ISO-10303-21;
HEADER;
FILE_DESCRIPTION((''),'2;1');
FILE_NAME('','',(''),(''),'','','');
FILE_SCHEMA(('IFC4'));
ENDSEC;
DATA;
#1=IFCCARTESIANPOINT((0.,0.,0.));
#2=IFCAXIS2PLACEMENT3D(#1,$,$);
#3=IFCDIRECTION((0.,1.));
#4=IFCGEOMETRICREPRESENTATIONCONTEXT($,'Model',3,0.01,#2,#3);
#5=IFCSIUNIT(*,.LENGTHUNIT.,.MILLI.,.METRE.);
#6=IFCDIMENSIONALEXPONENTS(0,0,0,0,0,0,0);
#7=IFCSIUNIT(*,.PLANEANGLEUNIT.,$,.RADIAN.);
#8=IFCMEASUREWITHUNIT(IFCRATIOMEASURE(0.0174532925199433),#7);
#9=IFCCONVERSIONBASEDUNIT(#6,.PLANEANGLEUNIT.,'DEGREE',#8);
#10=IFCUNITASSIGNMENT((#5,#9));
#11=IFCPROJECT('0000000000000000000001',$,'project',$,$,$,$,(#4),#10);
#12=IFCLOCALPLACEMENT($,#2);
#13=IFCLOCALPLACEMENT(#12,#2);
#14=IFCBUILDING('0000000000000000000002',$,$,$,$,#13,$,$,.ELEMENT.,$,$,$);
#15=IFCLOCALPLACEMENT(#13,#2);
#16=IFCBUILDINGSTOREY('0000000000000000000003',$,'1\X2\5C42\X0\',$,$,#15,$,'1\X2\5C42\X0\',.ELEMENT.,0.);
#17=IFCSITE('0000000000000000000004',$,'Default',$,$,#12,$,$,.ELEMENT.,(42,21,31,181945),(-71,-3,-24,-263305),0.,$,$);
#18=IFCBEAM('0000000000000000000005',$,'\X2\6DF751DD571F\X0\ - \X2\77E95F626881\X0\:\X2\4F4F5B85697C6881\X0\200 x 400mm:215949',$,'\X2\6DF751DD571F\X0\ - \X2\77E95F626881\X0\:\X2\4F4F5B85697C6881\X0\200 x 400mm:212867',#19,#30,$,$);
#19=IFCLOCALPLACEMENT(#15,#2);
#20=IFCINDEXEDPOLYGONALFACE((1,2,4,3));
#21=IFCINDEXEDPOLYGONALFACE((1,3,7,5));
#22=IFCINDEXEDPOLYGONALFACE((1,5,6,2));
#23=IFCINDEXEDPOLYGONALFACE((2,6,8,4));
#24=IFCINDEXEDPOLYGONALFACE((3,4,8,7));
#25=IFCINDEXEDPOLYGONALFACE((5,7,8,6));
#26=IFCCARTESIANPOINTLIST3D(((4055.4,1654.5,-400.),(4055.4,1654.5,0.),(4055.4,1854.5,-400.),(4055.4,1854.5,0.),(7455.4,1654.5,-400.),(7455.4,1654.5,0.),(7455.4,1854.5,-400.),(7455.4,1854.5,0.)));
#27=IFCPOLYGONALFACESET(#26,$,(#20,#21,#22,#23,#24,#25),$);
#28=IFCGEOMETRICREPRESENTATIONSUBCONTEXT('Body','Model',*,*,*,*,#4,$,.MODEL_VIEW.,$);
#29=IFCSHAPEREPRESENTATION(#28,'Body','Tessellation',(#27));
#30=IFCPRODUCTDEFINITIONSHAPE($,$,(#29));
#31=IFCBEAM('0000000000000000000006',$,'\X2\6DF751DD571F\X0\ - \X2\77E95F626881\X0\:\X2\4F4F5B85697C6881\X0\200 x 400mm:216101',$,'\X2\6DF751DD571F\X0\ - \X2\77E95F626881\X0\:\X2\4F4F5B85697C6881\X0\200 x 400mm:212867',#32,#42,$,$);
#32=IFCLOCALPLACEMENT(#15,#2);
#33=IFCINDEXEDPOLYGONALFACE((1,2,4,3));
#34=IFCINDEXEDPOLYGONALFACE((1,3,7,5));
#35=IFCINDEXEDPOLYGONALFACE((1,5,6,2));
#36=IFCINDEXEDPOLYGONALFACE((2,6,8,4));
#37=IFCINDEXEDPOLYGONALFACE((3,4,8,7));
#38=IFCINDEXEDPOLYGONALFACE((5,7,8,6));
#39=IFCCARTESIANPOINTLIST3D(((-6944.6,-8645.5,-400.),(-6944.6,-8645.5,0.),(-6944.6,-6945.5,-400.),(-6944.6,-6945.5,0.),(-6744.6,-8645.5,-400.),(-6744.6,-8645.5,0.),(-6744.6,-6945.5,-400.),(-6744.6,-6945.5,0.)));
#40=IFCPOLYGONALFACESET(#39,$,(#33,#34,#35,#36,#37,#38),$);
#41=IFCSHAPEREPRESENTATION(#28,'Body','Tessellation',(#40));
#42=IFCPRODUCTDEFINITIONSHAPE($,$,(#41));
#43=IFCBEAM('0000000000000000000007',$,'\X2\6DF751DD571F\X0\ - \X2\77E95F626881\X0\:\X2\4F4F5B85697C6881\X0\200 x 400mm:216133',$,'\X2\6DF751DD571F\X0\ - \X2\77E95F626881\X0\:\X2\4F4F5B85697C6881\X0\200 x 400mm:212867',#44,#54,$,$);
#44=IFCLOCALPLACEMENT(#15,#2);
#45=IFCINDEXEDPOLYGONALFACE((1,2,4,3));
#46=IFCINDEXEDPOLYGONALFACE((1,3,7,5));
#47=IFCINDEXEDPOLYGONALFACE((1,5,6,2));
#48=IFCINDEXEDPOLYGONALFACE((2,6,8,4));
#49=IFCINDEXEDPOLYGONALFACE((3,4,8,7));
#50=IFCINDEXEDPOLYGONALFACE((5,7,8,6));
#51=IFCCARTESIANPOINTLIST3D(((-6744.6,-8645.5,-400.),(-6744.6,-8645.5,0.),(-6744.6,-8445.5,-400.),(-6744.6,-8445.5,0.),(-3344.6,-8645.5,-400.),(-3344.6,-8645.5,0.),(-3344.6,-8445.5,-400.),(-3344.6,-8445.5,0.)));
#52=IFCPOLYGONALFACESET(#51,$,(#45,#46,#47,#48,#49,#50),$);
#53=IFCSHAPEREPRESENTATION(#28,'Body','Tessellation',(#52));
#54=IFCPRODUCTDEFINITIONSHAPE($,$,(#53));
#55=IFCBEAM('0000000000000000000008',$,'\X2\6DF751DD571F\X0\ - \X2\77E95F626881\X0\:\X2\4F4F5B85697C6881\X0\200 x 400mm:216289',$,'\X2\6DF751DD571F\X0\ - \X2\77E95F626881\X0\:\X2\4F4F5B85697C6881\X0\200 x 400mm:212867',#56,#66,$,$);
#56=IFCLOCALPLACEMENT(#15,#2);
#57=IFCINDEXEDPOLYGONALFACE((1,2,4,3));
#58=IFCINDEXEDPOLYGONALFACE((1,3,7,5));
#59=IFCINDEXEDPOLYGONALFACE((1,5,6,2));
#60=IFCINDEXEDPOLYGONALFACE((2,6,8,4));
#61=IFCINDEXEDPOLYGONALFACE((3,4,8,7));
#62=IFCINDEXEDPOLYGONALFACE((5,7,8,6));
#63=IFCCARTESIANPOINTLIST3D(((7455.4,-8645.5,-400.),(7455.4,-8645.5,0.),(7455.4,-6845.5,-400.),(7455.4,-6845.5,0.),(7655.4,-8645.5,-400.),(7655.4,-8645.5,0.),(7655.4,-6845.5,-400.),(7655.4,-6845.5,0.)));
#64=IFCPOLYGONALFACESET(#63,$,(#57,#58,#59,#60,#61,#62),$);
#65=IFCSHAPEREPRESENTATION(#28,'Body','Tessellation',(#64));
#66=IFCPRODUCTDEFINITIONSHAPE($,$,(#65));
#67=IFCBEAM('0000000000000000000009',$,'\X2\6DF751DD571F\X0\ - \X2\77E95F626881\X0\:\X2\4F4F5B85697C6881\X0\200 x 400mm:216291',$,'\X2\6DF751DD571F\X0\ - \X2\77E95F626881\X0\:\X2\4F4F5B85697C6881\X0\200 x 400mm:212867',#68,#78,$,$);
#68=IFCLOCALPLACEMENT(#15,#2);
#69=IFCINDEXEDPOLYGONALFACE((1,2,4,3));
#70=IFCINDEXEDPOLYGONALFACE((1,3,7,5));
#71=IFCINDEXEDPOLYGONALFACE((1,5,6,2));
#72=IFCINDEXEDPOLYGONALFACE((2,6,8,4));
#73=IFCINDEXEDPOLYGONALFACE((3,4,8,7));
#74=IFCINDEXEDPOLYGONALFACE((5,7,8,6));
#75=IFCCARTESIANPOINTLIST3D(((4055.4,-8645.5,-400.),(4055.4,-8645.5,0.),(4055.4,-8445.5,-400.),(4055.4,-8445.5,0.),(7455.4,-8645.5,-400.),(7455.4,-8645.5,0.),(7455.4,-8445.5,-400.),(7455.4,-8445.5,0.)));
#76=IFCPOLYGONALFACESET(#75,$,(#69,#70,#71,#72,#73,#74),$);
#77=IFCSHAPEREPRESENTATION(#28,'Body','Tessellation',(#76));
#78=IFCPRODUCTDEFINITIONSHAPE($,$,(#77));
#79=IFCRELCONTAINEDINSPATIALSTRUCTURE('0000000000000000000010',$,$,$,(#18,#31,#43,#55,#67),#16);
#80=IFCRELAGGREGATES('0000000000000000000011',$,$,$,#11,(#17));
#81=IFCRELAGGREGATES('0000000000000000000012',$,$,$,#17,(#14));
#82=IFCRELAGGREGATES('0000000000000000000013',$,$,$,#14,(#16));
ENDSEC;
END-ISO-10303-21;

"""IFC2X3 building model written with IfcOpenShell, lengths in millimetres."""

from ifc_helpers import new_model, entity, si_unit, converted_unit, direction, frame, frame_2d, origin, place, context, subcontext, project, spatial, rectangle, extrude, element, save


model = new_model("IFC2X3")

# Units and contexts
model_context = context("Model", 3, precision=0.01, world=origin(), true_north=direction((0.0, 1.0)))
body_context = subcontext(model_context, "Body", "Model", "MODEL_VIEW")
ifc_project = project(units=[si_unit("LENGTHUNIT", "METRE", prefix="MILLI"), converted_unit("PLANEANGLEUNIT", "DEGREE", entity("IfcRatioMeasure", 0.0174532925199433), si_unit("PLANEANGLEUNIT", "RADIAN"), dimensions=[0, 0, 0, 0, 0, 0, 0])], contexts=[model_context])

# Site, building, storey
site_placement = place(None, origin())
site = spatial("IfcSite", under=ifc_project, at=site_placement, Name="Default", CompositionType="ELEMENT", RefLatitude=(42, 21, 31, 181945), RefLongitude=(-71, -3, -24, -263305), RefElevation=0.0)
building_placement = place(site_placement, origin())
building = spatial("IfcBuilding", under=site, at=building_placement, CompositionType="ELEMENT")
storey_placement = place(building_placement, origin())
storey = spatial("IfcBuildingStorey", under=building, at=storey_placement, Name="1层", LongName="1层", CompositionType="ELEMENT", Elevation=0.0)

# Beams
beam_1_placement = place(storey_placement, frame((7555.4, 1754.5, 0.0), z_axis=(0.0, 0.0, 1.0), x_axis=(-1.0, 0.0, 0.0)))
element("IfcBeam", 1, at=beam_1_placement, inside=storey, Name="混凝土 - 矩形梁:住宅楼梁200 x 400mm:215949", ObjectType="混凝土 - 矩形梁:住宅楼梁200 x 400mm:212867", context=body_context, shape_type="SweptSolid", body=[
    extrude(rectangle(XDim=400.0, YDim=200.0, at=frame_2d((0.0, 0.0), x_axis=(1.0, 0.0))), frame((100.0, 0.0, -200.0), z_axis=(1.0, 0.0, 0.0), x_axis=(0.0, 0.0, -1.0)), (0.0, 0.0, 1.0), 3400.0),
])
beam_2_placement = place(storey_placement, frame((-6844.6, -6745.5, 0.0), z_axis=(0.0, 0.0, 1.0), x_axis=(0.0, -1.0, 0.0)))
element("IfcBeam", 2, at=beam_2_placement, inside=storey, Name="混凝土 - 矩形梁:住宅楼梁200 x 400mm:216101", ObjectType="混凝土 - 矩形梁:住宅楼梁200 x 400mm:212867", context=body_context, shape_type="SweptSolid", body=[
    extrude(rectangle(XDim=400.0, YDim=200.0, at=frame_2d((0.0, 0.0), x_axis=(1.0, 0.0))), frame((200.0, 0.0, -200.0), z_axis=(1.0, 0.0, 0.0), x_axis=(0.0, 0.0, -1.0)), (0.0, 0.0, 1.0), 1700.0),
])
beam_3_placement = place(storey_placement, frame((-6844.6, -8545.5, 0.0)))
element("IfcBeam", 3, at=beam_3_placement, inside=storey, Name="混凝土 - 矩形梁:住宅楼梁200 x 400mm:216133", ObjectType="混凝土 - 矩形梁:住宅楼梁200 x 400mm:212867", context=body_context, shape_type="SweptSolid", body=[
    extrude(rectangle(XDim=400.0, YDim=200.0, at=frame_2d((0.0, 0.0), x_axis=(1.0, 0.0))), frame((100.0, 0.0, -200.0), z_axis=(1.0, 0.0, 0.0), x_axis=(0.0, 0.0, -1.0)), (0.0, 0.0, 1.0), 3400.0),
])
beam_4_placement = place(storey_placement, frame((7555.4, -6745.5, 0.0), z_axis=(0.0, 0.0, 1.0), x_axis=(0.0, -1.0, 0.0)))
element("IfcBeam", 4, at=beam_4_placement, inside=storey, Name="混凝土 - 矩形梁:住宅楼梁200 x 400mm:216289", ObjectType="混凝土 - 矩形梁:住宅楼梁200 x 400mm:212867", context=body_context, shape_type="SweptSolid", body=[
    extrude(rectangle(XDim=400.0, YDim=200.0, at=frame_2d((0.0, 0.0), x_axis=(1.0, 0.0))), frame((100.0, 0.0, -200.0), z_axis=(1.0, 0.0, 0.0), x_axis=(0.0, 0.0, -1.0)), (0.0, 0.0, 1.0), 1800.0),
])
beam_5_placement = place(storey_placement, frame((7555.4, -8545.5, 0.0), z_axis=(0.0, 0.0, 1.0), x_axis=(-1.0, 0.0, 0.0)))
element("IfcBeam", 5, at=beam_5_placement, inside=storey, Name="混凝土 - 矩形梁:住宅楼梁200 x 400mm:216291", ObjectType="混凝土 - 矩形梁:住宅楼梁200 x 400mm:212867", context=body_context, shape_type="SweptSolid", body=[
    extrude(rectangle(XDim=400.0, YDim=200.0, at=frame_2d((0.0, 0.0), x_axis=(1.0, 0.0))), frame((100.0, 0.0, -200.0), z_axis=(1.0, 0.0, 0.0), x_axis=(0.0, 0.0, -1.0)), (0.0, 0.0, 1.0), 3400.0),
])

save(model, "model.ifc")
